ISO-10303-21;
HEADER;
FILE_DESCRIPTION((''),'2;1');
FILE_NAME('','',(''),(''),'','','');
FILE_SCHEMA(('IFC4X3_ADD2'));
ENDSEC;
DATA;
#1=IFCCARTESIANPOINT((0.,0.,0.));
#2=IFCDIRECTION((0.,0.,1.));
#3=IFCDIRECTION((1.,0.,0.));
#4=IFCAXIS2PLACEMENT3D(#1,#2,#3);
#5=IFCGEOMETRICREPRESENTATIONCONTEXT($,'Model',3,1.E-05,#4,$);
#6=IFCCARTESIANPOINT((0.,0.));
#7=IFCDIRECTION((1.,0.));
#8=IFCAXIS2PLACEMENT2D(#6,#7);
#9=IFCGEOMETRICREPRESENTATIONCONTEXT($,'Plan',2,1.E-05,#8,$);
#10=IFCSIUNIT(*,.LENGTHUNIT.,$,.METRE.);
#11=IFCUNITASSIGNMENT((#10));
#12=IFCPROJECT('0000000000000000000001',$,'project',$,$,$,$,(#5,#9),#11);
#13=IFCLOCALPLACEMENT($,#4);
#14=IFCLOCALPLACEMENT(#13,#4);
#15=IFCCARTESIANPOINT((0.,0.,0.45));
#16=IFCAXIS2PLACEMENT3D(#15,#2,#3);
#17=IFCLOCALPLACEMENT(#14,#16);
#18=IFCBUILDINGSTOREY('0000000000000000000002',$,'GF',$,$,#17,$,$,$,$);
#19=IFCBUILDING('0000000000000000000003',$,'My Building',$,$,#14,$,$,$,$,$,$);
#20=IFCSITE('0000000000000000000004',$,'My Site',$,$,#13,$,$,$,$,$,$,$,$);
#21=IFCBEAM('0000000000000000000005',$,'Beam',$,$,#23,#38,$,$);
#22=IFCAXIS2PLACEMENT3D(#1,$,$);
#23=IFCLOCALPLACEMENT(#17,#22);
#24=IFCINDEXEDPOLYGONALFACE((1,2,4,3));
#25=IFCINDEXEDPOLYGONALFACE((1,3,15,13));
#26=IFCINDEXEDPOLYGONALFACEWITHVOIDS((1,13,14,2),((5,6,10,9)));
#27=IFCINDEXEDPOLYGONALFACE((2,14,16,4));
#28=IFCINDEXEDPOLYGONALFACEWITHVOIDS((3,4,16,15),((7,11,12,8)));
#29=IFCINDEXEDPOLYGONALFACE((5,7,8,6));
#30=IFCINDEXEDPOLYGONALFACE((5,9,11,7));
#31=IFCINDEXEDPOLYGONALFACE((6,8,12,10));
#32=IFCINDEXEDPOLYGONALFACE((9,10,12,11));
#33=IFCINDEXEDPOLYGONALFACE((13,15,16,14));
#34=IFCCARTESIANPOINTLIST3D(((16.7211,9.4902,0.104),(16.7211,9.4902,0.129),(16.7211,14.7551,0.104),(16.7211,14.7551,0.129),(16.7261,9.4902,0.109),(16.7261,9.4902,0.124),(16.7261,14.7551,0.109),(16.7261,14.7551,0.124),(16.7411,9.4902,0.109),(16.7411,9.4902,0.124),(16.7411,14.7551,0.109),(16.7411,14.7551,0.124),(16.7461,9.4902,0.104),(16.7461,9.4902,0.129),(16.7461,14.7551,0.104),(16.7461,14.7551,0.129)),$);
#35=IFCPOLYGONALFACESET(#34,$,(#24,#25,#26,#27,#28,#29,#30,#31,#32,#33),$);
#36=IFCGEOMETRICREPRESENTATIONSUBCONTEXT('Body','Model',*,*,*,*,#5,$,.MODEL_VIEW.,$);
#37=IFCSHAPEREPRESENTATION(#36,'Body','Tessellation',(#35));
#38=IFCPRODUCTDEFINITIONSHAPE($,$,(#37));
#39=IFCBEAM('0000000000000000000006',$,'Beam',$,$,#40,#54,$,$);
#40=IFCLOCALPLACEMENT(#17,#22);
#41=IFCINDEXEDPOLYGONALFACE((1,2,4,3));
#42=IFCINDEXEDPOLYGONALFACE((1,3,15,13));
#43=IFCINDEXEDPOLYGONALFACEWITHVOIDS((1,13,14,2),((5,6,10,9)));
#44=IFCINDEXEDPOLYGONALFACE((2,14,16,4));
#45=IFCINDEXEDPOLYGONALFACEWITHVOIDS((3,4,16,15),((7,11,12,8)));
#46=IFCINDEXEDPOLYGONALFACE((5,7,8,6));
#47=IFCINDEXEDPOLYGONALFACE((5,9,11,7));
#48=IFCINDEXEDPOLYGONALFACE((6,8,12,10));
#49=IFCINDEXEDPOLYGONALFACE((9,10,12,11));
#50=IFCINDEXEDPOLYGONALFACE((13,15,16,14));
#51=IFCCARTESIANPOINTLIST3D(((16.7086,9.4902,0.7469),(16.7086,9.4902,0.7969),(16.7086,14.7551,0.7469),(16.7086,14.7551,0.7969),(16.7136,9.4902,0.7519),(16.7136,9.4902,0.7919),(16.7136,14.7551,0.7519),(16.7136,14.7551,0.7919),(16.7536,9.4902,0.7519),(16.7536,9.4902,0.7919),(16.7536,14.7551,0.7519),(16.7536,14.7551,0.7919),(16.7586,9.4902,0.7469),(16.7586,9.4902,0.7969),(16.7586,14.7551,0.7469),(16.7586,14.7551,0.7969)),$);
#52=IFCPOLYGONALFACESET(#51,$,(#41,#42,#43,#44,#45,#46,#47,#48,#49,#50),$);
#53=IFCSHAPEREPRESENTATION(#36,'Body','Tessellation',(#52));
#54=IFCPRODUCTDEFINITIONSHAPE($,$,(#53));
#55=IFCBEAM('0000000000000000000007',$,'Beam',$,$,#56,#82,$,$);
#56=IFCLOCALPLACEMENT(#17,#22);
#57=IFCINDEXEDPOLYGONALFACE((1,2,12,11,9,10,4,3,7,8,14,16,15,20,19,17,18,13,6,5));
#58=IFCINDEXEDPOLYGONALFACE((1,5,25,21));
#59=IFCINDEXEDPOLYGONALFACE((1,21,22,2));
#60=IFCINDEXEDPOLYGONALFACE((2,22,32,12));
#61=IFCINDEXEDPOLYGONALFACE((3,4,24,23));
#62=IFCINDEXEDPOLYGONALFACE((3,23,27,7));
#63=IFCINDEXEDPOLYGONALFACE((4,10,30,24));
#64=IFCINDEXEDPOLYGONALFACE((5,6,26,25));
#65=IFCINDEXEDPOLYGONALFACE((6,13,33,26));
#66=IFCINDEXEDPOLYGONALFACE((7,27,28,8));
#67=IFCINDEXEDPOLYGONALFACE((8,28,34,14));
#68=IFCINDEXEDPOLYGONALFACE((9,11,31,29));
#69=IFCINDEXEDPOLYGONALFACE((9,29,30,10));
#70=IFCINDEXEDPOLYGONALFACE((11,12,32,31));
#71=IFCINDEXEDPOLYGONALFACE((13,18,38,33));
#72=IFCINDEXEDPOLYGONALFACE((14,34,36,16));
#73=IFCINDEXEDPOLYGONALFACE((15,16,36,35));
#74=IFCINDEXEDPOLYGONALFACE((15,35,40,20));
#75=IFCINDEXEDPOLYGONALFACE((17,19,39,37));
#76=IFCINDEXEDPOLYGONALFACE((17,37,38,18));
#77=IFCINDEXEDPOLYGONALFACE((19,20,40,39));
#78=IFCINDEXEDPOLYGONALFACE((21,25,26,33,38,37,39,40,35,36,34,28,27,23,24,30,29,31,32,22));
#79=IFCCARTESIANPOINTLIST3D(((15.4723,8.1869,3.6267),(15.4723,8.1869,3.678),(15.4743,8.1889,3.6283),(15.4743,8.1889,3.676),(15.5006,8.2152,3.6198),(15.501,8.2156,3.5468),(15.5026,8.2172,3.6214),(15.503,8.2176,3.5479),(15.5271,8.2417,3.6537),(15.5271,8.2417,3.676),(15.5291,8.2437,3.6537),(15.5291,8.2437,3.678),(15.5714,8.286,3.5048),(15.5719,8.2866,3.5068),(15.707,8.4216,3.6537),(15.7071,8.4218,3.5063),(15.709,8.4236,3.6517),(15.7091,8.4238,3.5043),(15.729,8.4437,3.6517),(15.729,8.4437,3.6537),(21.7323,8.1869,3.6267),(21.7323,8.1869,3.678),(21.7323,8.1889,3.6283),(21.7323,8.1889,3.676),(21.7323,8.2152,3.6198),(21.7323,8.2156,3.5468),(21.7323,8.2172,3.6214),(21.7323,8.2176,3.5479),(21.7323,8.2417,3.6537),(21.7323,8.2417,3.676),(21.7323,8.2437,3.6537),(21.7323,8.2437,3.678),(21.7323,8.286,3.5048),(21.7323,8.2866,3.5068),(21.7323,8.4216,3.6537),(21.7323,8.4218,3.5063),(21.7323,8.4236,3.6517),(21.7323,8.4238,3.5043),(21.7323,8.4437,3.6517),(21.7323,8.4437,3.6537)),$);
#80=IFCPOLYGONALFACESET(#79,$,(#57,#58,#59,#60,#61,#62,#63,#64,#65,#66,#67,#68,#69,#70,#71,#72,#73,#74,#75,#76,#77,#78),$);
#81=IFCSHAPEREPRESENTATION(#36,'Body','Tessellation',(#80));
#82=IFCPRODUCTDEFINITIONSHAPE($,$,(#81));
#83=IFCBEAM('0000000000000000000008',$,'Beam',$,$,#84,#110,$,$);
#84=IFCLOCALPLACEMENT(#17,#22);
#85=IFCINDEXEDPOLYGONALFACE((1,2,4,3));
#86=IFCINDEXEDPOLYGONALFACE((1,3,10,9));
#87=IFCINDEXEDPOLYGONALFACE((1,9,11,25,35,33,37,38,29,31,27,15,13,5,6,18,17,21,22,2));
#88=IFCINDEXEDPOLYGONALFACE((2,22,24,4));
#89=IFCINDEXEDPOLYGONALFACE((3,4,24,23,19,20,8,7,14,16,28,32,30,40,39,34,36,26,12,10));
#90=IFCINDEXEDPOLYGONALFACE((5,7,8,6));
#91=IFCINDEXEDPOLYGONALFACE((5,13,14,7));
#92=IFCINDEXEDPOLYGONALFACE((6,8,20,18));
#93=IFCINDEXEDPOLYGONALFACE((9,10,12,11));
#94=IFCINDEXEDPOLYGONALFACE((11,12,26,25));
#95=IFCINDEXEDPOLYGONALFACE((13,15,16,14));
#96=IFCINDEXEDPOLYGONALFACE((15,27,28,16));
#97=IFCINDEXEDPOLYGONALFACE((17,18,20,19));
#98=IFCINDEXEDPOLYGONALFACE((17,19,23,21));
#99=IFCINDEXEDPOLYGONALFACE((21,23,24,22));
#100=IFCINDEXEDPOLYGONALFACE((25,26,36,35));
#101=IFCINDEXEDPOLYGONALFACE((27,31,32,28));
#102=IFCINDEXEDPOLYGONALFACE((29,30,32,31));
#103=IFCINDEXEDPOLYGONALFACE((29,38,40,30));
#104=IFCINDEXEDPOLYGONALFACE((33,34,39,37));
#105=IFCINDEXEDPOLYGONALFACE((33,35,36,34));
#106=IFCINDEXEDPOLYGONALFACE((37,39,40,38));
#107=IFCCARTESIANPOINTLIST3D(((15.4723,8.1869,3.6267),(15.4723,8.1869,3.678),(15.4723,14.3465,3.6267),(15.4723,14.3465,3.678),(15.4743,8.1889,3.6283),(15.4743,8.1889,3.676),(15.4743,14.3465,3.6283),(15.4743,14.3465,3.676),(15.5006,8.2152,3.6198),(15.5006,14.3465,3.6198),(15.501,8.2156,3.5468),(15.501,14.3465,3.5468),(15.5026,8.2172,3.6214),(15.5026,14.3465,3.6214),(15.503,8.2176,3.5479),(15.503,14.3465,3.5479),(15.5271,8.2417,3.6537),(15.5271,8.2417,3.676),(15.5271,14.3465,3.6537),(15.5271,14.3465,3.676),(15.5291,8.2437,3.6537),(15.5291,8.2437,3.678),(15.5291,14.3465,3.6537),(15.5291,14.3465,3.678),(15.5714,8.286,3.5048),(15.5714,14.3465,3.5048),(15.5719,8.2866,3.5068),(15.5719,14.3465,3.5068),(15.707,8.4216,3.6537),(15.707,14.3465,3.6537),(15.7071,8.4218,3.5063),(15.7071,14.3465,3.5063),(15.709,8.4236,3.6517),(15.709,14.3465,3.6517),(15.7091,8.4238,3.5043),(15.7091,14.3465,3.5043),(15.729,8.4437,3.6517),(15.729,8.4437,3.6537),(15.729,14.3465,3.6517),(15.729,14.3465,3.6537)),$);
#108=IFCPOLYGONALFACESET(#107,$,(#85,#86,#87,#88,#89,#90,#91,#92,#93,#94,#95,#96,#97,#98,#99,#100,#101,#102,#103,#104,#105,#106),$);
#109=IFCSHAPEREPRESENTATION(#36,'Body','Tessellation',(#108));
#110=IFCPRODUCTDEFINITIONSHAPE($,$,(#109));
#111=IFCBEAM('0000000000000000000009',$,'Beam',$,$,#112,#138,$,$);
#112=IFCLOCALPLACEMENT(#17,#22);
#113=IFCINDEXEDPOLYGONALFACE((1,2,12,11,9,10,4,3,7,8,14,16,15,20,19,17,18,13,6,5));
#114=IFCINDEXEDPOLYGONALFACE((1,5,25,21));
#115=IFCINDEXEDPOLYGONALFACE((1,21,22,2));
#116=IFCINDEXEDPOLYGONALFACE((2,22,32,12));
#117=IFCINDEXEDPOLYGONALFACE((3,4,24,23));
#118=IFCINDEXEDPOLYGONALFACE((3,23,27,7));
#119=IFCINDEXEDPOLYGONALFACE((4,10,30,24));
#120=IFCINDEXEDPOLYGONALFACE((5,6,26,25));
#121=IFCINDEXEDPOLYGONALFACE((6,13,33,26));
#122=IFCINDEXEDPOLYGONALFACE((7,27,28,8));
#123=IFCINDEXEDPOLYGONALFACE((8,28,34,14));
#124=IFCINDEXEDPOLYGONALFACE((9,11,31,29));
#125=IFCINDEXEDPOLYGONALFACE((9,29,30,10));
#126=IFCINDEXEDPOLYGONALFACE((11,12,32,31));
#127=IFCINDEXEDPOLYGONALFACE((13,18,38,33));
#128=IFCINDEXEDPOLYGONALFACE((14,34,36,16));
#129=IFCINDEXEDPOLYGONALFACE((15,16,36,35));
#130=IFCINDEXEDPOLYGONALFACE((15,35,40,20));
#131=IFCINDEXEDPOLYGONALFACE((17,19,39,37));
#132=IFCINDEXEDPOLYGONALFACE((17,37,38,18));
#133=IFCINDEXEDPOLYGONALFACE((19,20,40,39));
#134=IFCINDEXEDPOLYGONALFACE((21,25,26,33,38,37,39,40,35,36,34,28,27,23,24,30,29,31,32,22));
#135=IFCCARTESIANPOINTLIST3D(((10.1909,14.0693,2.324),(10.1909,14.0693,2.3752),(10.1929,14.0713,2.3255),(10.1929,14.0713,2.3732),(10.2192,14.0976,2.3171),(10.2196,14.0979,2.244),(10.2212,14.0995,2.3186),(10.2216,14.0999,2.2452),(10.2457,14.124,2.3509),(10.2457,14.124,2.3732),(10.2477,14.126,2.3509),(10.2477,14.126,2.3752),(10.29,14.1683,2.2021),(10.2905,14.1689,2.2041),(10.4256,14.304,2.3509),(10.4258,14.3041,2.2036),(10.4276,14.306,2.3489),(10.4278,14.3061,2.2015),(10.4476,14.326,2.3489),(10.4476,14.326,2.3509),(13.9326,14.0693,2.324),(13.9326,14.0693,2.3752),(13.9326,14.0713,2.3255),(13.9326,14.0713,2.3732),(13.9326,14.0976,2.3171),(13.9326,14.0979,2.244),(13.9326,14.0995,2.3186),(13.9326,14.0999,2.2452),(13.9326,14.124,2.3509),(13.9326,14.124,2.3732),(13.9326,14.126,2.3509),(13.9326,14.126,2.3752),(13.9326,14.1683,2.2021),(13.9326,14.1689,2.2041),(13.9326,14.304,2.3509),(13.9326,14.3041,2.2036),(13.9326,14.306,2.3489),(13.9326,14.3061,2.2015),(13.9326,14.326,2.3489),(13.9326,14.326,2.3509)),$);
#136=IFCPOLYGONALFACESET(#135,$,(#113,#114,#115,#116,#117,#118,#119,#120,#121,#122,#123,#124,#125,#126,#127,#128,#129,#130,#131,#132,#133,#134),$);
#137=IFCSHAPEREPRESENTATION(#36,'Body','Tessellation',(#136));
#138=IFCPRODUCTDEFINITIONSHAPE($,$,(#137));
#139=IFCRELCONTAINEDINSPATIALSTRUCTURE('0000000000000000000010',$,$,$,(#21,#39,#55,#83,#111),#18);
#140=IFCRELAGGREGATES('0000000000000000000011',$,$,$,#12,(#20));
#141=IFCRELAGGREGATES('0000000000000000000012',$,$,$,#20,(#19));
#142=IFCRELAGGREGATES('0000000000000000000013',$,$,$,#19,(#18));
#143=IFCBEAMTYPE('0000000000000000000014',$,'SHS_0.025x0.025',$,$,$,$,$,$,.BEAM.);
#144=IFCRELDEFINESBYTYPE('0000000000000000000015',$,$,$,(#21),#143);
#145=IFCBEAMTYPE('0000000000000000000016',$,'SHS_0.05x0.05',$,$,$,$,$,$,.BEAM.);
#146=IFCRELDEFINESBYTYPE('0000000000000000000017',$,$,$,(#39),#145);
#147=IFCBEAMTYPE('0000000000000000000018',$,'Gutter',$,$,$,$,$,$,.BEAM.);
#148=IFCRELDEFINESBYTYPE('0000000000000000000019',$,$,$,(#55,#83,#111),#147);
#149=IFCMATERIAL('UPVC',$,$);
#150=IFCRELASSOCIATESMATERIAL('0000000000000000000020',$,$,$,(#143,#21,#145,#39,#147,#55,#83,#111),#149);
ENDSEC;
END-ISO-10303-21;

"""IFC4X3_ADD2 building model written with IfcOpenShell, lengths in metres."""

from ifc_helpers import new_model, si_unit, frame, origin_with_axes, origin_2d_with_axis, place, context, subcontext, project, spatial, indexed_curve, hollow_rectangle, outline, extrude, clip, halfspace, material, material_profile, profile_set, profile_usage, type_object, element, save


model = new_model("IFC4X3_ADD2")

# Units and contexts
model_context = context("Model", 3, precision=1e-05, world=origin_with_axes())
plan_context = context("Plan", 2, precision=1e-05, world=origin_2d_with_axis())
body_context = subcontext(model_context, "Body", "Model", "MODEL_VIEW")
ifc_project = project(units=[si_unit("LENGTHUNIT", "METRE")], contexts=[model_context, plan_context])

# Site, building, storey
site_placement = place(None, origin_with_axes())
site = spatial("IfcSite", under=ifc_project, at=site_placement, Name="My Site")
building_placement = place(site_placement, origin_with_axes())
building = spatial("IfcBuilding", under=site, at=building_placement, Name="My Building")
storey_placement = place(building_placement, frame((0.0, 0.0, 0.45), z_axis=(0.0, 0.0, 1.0), x_axis=(1.0, 0.0, 0.0)))
storey = spatial("IfcBuildingStorey", under=building, at=storey_placement, Name="GF")

# Shared definitions
ifc_material_1 = material(Name="UPVC")

# Beams
ifc_material_profile_1 = material_profile(ifc_material_1, hollow_rectangle(XDim=0.025, YDim=0.025, WallThickness=0.005))
ifc_profile_set_1 = profile_set([ifc_material_profile_1])
beam_type_1 = type_object("IfcBeamType", Name="SHS_0.025x0.025", PredefinedType="BEAM", material=ifc_profile_set_1)
ifc_profile_usage_1 = profile_usage(ifc_profile_set_1)
beam_1_placement = place(storey_placement, frame((16.7336, 14.7551, 0.1165), z_axis=(0.0, -1.0, 0.0), x_axis=(1.0, 0.0, 0.0)))
element("IfcBeam", 1, at=beam_1_placement, inside=storey, type_object=beam_type_1, material=ifc_profile_usage_1, Name="Beam", context=body_context, shape_type="SweptSolid", body=[
    extrude(hollow_rectangle(XDim=0.025, YDim=0.025, WallThickness=0.005), origin_with_axes(), (0.0, 0.0, 1.0), 5.2649),
])
ifc_material_profile_2 = material_profile(ifc_material_1, hollow_rectangle(XDim=0.05, YDim=0.05, WallThickness=0.005))
ifc_profile_set_2 = profile_set([ifc_material_profile_2])
ifc_profile_usage_2 = profile_usage(ifc_profile_set_2)
beam_type_2 = type_object("IfcBeamType", Name="SHS_0.05x0.05", PredefinedType="BEAM", material=ifc_profile_set_2)
beam_2_placement = place(storey_placement, frame((16.7336, 14.7551, 0.7719), z_axis=(0.0, -1.0, 0.0), x_axis=(1.0, 0.0, 0.0)))
element("IfcBeam", 2, at=beam_2_placement, inside=storey, type_object=beam_type_2, material=ifc_profile_usage_2, Name="Beam", context=body_context, shape_type="SweptSolid", body=[
    extrude(hollow_rectangle(XDim=0.05, YDim=0.05, WallThickness=0.005), origin_with_axes(), (0.0, 0.0, 1.0), 5.2649),
])
ifc_material_profile_3 = material_profile(ifc_material_1, outline(indexed_curve([(0.0548, 0.1717), (0.002, 0.1717), (0.002, 0.124), (0.0303, 0.1171), (0.0307, 0.0436), (0.0996, 0.0025), (0.2349, 0.002), (0.2347, 0.1494), (0.2567, 0.1494), (0.2567, 0.1474), (0.2367, 0.1474), (0.2369, 0.0), (0.0991, 0.0005), (0.0287, 0.0425), (0.0283, 0.1155), (0.0, 0.1224), (0.0, 0.1737), (0.0568, 0.1737), (0.0568, 0.1494), (0.0548, 0.1494), (0.0548, 0.1717)])))
ifc_profile_set_3 = profile_set([ifc_material_profile_3])
ifc_profile_usage_3 = profile_usage(ifc_profile_set_3)
beam_type_3 = type_object("IfcBeamType", Name="Gutter", PredefinedType="BEAM", material=ifc_profile_set_3)
beam_3_placement = place(storey_placement, frame((15.4723, 8.1869, 3.5043), z_axis=(1.0, 0.0, 0.0), x_axis=(0.0, 1.0, 0.0)))
element("IfcBeam", 3, at=beam_3_placement, inside=storey, type_object=beam_type_3, material=ifc_profile_usage_3, Name="Beam", context=body_context, shape_type="Clipping", body=[
    clip(extrude(outline(indexed_curve([(0.0548, 0.1717), (0.002, 0.1717), (0.002, 0.124), (0.0303, 0.1171), (0.0307, 0.0436), (0.0996, 0.0025), (0.2349, 0.002), (0.2347, 0.1494), (0.2567, 0.1494), (0.2567, 0.1474), (0.2367, 0.1474), (0.2369, 0.0), (0.0991, 0.0005), (0.0287, 0.0425), (0.0283, 0.1155), (0.0, 0.1224), (0.0, 0.1737), (0.0568, 0.1737), (0.0568, 0.1494), (0.0548, 0.1494), (0.0548, 0.1717)])), origin_with_axes(), (0.0, 0.0, 1.0), 6.26), halfspace(frame((0.0, -3.9543, 0.0), z_axis=(0.707107, 0.0, -0.707107), x_axis=(0.0, -1.0, 0.0)), False)),
])
ifc_profile_usage_4 = profile_usage(ifc_profile_set_3)
beam_4_placement = place(storey_placement, frame((15.4723, 14.3465, 3.5043), z_axis=(0.0, -1.0, 0.0), x_axis=(1.0, 0.0, 0.0)))
element("IfcBeam", 4, at=beam_4_placement, inside=storey, type_object=beam_type_3, material=ifc_profile_usage_4, Name="Beam", context=body_context, shape_type="Clipping", body=[
    clip(extrude(outline(indexed_curve([(0.0548, 0.1717), (0.002, 0.1717), (0.002, 0.124), (0.0303, 0.1171), (0.0307, 0.0436), (0.0996, 0.0025), (0.2349, 0.002), (0.2347, 0.1494), (0.2567, 0.1494), (0.2567, 0.1474), (0.2367, 0.1474), (0.2369, 0.0), (0.0991, 0.0005), (0.0287, 0.0425), (0.0283, 0.1155), (0.0, 0.1224), (0.0, 0.1737), (0.0568, 0.1737), (0.0568, 0.1494), (0.0548, 0.1494), (0.0548, 0.1717)])), origin_with_axes(), (0.0, 0.0, 1.0), 6.1596), halfspace(frame((0.0, -3.9543, 6.1596), z_axis=(0.707107, 0.0, 0.707106), x_axis=(0.0, -1.0, 0.0)), False)),
])
ifc_profile_usage_5 = profile_usage(ifc_profile_set_3)
beam_5_placement = place(storey_placement, frame((10.1909, 14.0693, 2.2015), z_axis=(1.0, 0.0, 0.0), x_axis=(0.0, 1.0, 0.0)))
element("IfcBeam", 5, at=beam_5_placement, inside=storey, type_object=beam_type_3, material=ifc_profile_usage_5, Name="Beam", context=body_context, shape_type="Clipping", body=[
    clip(extrude(outline(indexed_curve([(0.0548, 0.1717), (0.002, 0.1717), (0.002, 0.124), (0.0303, 0.1171), (0.0307, 0.0436), (0.0996, 0.0025), (0.2349, 0.002), (0.2347, 0.1494), (0.2567, 0.1494), (0.2567, 0.1474), (0.2367, 0.1474), (0.2369, 0.0), (0.0991, 0.0005), (0.0287, 0.0425), (0.0283, 0.1155), (0.0, 0.1224), (0.0, 0.1737), (0.0568, 0.1737), (0.0568, 0.1494), (0.0548, 0.1494), (0.0548, 0.1717)])), origin_with_axes(), (0.0, 0.0, 1.0), 3.7417), halfspace(frame((0.0, -2.6516, 0.0), z_axis=(0.707106, 0.0, -0.707107), x_axis=(0.0, -1.0, 0.0)), False)),
])

save(model, "model.ifc")
